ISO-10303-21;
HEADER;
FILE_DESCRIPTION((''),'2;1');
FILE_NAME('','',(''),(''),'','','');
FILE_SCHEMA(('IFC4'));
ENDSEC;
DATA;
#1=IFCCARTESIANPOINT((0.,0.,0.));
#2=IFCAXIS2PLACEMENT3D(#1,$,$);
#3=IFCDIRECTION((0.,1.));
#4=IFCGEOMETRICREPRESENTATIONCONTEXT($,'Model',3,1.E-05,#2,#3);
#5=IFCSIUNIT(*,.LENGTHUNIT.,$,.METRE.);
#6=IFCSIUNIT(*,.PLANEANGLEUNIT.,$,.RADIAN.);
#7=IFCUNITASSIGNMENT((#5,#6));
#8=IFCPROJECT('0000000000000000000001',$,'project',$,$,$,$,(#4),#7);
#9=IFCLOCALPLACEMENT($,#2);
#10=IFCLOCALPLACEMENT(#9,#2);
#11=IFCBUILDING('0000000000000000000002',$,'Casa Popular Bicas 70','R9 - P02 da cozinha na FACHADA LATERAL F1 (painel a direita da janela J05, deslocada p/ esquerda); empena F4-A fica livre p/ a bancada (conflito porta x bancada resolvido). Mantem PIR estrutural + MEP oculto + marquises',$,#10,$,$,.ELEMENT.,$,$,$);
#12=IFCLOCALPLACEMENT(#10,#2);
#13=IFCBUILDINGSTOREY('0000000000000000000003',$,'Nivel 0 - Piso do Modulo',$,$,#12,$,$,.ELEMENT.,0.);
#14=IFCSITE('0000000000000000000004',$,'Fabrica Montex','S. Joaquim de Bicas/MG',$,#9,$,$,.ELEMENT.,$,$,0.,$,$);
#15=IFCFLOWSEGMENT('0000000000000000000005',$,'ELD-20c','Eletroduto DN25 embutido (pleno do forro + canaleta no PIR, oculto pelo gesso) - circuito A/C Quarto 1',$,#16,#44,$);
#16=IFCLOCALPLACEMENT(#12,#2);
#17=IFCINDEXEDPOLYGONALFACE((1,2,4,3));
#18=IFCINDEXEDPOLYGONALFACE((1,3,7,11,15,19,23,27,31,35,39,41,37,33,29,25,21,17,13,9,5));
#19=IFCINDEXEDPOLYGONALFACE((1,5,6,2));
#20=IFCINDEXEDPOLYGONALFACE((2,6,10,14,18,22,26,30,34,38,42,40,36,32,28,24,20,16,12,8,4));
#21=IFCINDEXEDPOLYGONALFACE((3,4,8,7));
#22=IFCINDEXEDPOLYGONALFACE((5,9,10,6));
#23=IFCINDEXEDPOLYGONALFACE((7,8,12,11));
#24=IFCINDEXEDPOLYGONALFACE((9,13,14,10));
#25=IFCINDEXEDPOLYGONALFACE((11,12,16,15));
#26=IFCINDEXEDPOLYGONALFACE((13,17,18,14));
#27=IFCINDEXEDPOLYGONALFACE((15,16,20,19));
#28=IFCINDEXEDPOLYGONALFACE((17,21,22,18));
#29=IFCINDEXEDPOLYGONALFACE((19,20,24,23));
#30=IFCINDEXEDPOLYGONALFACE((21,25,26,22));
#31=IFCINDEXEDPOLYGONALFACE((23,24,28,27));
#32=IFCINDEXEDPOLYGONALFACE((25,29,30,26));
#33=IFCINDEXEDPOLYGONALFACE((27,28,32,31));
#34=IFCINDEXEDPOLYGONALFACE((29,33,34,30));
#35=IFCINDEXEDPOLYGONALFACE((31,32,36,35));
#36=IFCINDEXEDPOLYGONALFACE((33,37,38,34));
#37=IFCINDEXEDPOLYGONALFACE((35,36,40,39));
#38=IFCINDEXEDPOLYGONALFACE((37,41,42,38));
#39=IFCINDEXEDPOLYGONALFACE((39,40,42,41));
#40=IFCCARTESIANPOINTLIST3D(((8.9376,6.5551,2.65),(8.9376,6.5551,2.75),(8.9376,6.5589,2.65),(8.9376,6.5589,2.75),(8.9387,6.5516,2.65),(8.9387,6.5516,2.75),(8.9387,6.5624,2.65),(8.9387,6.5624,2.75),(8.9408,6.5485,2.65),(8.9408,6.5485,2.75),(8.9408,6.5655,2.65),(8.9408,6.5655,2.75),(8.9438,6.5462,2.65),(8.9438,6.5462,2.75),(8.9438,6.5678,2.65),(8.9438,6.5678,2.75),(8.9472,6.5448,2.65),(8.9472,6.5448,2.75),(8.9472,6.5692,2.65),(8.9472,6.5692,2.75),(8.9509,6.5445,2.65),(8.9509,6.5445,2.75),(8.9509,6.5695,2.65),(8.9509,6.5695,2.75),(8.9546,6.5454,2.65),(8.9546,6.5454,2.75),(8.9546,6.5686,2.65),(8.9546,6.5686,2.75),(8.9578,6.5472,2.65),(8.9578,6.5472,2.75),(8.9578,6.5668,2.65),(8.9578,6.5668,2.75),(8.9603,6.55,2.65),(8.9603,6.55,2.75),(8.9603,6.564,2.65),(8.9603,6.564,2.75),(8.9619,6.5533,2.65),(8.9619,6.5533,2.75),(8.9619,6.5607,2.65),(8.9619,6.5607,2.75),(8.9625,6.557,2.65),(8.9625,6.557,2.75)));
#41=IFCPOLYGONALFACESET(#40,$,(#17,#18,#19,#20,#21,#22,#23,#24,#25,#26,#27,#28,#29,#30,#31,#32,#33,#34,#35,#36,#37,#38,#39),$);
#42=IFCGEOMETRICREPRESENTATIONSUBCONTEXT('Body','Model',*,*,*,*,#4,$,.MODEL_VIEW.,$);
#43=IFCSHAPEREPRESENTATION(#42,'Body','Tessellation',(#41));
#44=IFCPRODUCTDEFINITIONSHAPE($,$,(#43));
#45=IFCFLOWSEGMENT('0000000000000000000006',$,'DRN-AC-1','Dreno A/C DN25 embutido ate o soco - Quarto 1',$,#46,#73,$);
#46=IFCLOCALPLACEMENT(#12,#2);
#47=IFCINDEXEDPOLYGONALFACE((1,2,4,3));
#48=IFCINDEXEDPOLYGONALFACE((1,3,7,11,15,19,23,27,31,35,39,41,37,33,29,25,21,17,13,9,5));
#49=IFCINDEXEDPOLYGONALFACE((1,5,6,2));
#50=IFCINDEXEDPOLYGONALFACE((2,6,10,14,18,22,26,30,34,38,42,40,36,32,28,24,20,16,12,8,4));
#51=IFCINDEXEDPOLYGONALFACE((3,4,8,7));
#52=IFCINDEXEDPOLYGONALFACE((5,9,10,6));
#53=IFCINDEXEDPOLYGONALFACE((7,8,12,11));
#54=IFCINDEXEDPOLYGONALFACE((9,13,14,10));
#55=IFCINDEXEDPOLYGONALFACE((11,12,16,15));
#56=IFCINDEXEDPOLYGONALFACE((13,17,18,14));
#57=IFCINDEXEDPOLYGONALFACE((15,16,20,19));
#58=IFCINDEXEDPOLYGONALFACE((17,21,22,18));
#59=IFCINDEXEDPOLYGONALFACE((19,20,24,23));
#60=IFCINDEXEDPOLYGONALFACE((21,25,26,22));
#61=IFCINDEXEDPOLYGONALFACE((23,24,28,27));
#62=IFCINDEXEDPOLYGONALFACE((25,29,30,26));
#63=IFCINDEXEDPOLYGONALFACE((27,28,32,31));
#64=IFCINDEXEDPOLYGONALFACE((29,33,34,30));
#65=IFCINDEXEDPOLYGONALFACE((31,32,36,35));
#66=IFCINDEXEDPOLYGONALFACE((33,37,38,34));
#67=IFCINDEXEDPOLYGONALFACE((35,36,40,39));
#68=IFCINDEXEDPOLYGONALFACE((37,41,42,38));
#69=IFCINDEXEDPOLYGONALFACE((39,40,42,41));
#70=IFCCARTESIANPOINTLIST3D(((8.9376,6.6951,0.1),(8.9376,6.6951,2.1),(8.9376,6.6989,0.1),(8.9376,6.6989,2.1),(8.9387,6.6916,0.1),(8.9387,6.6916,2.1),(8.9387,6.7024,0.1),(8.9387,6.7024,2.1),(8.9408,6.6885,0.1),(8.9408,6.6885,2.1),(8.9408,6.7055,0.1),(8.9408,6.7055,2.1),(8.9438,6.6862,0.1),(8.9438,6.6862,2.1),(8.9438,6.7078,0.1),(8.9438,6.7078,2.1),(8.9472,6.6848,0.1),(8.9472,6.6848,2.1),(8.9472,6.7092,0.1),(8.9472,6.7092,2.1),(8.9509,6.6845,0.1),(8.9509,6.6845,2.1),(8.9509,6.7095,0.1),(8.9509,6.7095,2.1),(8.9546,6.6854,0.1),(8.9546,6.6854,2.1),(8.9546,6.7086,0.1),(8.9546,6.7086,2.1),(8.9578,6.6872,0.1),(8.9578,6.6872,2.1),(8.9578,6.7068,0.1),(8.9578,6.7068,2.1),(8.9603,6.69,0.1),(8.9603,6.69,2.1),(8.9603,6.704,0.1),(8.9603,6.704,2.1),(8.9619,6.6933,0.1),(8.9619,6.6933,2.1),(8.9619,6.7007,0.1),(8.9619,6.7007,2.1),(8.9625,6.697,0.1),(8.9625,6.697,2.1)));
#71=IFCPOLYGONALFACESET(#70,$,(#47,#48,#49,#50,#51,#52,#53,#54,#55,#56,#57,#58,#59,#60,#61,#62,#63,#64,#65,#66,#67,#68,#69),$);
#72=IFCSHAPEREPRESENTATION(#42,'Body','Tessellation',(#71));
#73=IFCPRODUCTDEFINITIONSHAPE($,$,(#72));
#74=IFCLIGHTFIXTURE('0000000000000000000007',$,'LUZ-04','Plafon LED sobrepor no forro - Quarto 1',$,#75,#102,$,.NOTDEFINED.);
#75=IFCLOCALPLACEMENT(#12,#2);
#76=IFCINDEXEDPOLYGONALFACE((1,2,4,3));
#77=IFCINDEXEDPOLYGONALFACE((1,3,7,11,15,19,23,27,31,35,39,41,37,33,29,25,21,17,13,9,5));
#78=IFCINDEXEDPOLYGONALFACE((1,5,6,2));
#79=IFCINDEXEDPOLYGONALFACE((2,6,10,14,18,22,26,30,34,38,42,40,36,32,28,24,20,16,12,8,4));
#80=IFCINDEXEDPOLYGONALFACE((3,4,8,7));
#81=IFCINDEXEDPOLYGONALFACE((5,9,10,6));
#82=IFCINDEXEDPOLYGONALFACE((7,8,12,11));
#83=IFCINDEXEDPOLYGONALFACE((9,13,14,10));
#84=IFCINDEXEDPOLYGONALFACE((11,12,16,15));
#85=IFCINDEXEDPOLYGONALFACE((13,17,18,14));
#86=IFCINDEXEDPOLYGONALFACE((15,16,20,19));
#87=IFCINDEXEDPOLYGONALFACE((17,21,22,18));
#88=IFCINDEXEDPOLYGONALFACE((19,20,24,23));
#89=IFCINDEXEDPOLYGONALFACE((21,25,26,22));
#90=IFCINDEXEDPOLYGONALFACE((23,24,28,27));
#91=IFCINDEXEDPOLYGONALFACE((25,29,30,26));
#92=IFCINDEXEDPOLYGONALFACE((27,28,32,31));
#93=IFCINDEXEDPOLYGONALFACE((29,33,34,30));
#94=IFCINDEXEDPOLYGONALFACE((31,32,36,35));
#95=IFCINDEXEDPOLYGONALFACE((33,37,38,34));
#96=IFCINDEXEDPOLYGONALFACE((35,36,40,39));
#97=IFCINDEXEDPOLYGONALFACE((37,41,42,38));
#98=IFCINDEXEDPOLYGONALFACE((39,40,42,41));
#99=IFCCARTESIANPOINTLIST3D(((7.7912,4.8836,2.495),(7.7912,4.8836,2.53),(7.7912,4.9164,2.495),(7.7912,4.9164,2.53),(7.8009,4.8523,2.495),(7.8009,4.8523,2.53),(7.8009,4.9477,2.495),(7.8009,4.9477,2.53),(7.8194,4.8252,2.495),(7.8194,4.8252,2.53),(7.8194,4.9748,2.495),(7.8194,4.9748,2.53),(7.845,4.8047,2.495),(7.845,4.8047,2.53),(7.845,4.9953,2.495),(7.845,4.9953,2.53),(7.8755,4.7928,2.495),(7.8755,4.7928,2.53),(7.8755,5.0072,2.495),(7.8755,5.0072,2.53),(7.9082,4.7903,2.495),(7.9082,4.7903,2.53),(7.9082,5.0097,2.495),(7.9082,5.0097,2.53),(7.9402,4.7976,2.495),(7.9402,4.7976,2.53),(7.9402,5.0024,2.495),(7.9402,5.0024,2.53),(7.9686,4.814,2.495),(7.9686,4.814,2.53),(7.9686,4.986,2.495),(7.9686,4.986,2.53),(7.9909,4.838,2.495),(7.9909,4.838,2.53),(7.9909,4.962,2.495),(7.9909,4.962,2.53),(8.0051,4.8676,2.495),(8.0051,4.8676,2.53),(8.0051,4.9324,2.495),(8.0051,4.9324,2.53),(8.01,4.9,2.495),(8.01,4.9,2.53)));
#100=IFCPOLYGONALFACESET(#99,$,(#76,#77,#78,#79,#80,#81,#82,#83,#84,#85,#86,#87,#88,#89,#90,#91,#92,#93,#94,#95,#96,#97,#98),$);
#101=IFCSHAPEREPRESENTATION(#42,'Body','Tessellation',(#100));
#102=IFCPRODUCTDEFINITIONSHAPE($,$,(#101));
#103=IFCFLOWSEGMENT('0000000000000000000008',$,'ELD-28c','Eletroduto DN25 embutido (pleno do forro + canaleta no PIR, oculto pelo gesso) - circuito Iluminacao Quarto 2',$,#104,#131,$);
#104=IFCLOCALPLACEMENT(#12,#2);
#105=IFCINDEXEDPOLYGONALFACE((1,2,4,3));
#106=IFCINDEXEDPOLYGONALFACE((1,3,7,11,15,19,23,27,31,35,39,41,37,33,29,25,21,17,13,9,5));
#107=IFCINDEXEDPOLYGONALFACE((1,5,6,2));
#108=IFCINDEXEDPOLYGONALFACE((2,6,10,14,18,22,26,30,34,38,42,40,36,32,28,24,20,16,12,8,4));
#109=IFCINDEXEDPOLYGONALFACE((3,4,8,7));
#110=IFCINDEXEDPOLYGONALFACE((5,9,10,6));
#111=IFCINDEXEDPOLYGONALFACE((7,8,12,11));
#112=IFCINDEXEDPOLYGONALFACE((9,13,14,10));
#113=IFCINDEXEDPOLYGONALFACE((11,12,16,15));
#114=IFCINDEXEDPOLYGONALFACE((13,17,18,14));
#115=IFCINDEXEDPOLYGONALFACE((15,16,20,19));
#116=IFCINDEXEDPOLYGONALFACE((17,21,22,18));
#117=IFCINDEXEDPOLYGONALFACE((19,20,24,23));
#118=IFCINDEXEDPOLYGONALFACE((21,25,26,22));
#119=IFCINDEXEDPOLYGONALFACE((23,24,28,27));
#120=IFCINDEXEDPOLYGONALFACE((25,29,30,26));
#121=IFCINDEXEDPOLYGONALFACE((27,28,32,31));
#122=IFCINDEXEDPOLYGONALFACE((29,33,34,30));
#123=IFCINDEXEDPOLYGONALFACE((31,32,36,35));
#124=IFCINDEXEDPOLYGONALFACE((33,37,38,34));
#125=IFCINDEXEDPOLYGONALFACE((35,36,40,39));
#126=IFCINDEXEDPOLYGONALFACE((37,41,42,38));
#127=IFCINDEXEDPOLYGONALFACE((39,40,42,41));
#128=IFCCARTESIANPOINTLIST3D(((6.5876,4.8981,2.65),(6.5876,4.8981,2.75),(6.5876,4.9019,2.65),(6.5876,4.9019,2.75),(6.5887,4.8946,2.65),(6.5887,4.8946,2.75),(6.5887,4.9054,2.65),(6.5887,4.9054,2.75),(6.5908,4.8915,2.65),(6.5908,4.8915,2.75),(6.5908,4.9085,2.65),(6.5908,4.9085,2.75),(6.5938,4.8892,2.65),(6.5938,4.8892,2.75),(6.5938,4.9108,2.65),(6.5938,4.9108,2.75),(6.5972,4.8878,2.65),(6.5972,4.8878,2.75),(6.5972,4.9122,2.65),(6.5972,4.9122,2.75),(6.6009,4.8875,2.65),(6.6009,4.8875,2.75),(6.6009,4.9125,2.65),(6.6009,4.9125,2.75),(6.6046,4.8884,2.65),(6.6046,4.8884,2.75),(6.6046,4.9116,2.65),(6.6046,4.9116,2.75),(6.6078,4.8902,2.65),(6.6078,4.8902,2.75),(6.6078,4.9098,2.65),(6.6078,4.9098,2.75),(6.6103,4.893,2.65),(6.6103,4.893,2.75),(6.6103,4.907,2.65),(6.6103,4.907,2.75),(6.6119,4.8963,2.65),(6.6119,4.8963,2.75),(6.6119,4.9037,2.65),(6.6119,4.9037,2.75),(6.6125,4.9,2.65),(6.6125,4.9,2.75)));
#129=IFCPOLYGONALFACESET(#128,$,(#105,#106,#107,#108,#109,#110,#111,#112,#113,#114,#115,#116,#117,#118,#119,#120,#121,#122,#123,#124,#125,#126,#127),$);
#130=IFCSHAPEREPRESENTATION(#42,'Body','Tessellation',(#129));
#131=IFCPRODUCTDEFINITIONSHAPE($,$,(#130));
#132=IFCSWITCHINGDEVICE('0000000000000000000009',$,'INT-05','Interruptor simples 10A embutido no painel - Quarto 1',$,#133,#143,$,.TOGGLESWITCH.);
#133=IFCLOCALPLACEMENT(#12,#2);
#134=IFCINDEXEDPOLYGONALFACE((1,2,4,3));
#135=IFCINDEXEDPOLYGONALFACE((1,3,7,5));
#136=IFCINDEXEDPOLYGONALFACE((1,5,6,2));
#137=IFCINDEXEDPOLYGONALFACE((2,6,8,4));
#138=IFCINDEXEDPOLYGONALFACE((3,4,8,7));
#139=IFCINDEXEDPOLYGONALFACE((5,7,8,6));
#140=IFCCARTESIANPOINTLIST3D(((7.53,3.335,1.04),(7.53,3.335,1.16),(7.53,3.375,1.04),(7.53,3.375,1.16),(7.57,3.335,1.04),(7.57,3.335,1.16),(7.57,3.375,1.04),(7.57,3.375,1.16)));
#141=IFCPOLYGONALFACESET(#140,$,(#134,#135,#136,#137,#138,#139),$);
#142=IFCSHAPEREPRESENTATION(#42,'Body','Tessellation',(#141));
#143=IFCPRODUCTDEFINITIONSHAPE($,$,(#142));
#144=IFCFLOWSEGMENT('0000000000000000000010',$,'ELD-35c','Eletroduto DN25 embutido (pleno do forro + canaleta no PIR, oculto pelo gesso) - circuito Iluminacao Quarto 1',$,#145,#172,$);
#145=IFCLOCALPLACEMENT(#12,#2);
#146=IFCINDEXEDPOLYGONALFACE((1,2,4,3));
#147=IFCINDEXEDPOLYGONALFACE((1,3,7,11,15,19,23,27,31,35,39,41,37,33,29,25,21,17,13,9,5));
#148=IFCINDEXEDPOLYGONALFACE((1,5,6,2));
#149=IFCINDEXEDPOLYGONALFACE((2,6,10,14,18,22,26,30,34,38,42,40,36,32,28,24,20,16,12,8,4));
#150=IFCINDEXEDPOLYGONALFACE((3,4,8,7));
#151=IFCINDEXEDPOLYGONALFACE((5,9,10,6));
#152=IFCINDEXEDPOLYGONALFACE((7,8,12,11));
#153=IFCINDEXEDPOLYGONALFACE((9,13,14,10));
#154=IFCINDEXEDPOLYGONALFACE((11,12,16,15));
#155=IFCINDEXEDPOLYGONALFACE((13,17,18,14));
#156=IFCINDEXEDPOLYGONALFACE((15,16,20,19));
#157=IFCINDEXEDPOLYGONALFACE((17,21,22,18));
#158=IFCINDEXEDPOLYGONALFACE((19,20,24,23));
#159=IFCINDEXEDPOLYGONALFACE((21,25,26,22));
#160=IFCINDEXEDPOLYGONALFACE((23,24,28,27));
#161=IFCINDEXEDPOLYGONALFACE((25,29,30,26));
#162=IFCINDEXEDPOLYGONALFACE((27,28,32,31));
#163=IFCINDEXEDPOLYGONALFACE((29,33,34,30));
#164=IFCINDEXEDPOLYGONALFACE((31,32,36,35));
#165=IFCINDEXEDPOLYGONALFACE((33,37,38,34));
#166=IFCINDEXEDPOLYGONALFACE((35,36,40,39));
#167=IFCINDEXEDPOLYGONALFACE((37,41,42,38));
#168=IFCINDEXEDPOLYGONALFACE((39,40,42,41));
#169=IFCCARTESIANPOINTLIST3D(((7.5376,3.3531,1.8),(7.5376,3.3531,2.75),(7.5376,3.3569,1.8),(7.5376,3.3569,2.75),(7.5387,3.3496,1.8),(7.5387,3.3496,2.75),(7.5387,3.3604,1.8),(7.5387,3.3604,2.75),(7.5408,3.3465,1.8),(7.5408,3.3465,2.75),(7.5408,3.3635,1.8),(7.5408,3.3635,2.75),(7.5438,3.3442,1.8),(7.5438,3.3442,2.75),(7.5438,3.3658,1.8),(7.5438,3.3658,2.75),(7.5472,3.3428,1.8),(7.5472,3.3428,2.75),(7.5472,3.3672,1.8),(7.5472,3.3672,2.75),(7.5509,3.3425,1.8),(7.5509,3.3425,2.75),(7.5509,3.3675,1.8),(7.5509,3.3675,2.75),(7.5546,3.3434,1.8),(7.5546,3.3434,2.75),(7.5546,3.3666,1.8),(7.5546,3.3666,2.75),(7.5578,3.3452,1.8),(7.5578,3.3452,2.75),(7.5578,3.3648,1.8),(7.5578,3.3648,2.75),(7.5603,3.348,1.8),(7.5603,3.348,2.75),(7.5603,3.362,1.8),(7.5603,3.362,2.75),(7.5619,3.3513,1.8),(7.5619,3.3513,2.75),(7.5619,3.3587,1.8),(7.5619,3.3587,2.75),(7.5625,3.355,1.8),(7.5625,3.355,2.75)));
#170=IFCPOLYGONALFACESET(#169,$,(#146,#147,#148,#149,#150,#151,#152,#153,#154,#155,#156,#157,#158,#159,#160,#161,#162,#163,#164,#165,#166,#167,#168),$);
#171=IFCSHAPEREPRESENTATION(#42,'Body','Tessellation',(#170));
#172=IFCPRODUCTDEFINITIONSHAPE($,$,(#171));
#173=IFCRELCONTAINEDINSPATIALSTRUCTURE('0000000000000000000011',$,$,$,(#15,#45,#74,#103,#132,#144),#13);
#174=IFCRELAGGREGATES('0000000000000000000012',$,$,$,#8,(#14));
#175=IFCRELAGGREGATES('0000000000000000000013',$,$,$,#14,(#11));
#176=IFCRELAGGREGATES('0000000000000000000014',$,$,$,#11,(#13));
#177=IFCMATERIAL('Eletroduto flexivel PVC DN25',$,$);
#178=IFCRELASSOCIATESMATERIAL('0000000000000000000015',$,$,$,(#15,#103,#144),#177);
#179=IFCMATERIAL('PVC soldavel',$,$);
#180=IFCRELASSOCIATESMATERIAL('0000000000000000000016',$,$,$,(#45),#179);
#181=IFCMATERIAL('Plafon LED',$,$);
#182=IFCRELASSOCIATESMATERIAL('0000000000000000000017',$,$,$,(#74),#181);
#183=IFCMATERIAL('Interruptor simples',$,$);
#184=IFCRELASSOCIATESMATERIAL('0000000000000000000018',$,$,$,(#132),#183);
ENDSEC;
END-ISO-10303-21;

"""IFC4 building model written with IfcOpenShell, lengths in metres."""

from ifc_helpers import new_model, si_unit, direction, frame, frame_2d, origin, origin_2d, place, context, subcontext, project, spatial, rectangle, circle, extrude, material, element, save


model = new_model("IFC4")

# Units and contexts
model_context_1 = context("Model", 3, precision=1e-05, world=origin(), true_north=direction((0.0, 1.0)))
body_context_1 = subcontext(model_context_1, "Body", "Model", "MODEL_VIEW")
ifc_project = project(units=[si_unit("LENGTHUNIT", "METRE"), si_unit("PLANEANGLEUNIT", "RADIAN")], contexts=[model_context_1])

# Site, building, storey
site_placement = place(None, origin())
site = spatial("IfcSite", under=ifc_project, at=site_placement, Name="Fabrica Montex", Description="S. Joaquim de Bicas/MG", CompositionType="ELEMENT", RefElevation=0.0)
building_placement = place(site_placement, origin())
building = spatial("IfcBuilding", under=site, at=building_placement, Name="Casa Popular Bicas 70", Description="R9 - P02 da cozinha na FACHADA LATERAL F1 (painel a direita da janela J05, deslocada p/ esquerda); empena F4-A fica livre p/ a bancada (conflito porta x bancada resolvido). Mantem PIR estrutural + MEP oculto + marquises", CompositionType="ELEMENT")
storey_placement = place(building_placement, origin())
storey = spatial("IfcBuildingStorey", under=building, at=storey_placement, Name="Nivel 0 - Piso do Modulo", CompositionType="ELEMENT", Elevation=0.0)

# Shared definitions
ifc_material_1 = material(Name="Eletroduto flexivel PVC DN25")

# Flow segments
flow_segment_1_placement = place(storey_placement, frame((8.95, 6.557, 2.75), z_axis=(0.0, 0.0, -1.0), x_axis=(1.0, 0.0, 0.0)))
element("IfcFlowSegment", 1, at=flow_segment_1_placement, inside=storey, material=ifc_material_1, Name="ELD-20c", Description="Eletroduto DN25 embutido (pleno do forro + canaleta no PIR, oculto pelo gesso) - circuito A/C Quarto 1", context=body_context_1, shape_type="SweptSolid", body=[
    extrude(circle(Radius=0.0125, at=origin_2d()), origin(), (0.0, 0.0, 1.0), 0.1),
])
ifc_material_2 = material(Name="PVC soldavel")
flow_segment_2_placement = place(storey_placement, frame((8.95, 6.697, 2.1), z_axis=(0.0, 0.0, -1.0), x_axis=(1.0, 0.0, 0.0)))
element("IfcFlowSegment", 2, at=flow_segment_2_placement, inside=storey, material=ifc_material_2, Name="DRN-AC-1", Description="Dreno A/C DN25 embutido ate o soco - Quarto 1", context=body_context_1, shape_type="SweptSolid", body=[
    extrude(circle(Radius=0.0125, at=origin_2d()), origin(), (0.0, 0.0, 1.0), 2.0),
])

# Light fixture
ifc_material_3 = material(Name="Plafon LED")
light_fixture_placement = place(storey_placement, frame((7.9, 4.9, 2.495)))
element("IfcLightFixture", 3, at=light_fixture_placement, inside=storey, material=ifc_material_3, Name="LUZ-04", Description="Plafon LED sobrepor no forro - Quarto 1", PredefinedType="NOTDEFINED", context=body_context_1, shape_type="SweptSolid", body=[
    extrude(circle(Radius=0.11, at=origin_2d()), origin(), (0.0, 0.0, 1.0), 0.035),
])

# Flow segment
flow_segment_3_placement = place(storey_placement, frame((6.6, 4.9, 2.75), z_axis=(0.0, 0.0, -1.0), x_axis=(1.0, 0.0, 0.0)))
element("IfcFlowSegment", 4, at=flow_segment_3_placement, inside=storey, material=ifc_material_1, Name="ELD-28c", Description="Eletroduto DN25 embutido (pleno do forro + canaleta no PIR, oculto pelo gesso) - circuito Iluminacao Quarto 2", context=body_context_1, shape_type="SweptSolid", body=[
    extrude(circle(Radius=0.0125, at=origin_2d()), origin(), (0.0, 0.0, 1.0), 0.1),
])

# Switching device
ifc_material_4 = material(Name="Interruptor simples")
switching_device_placement = place(storey_placement, frame((7.53, 3.335, 1.04)))
element("IfcSwitchingDevice", 5, at=switching_device_placement, inside=storey, material=ifc_material_4, Name="INT-05", Description="Interruptor simples 10A embutido no painel - Quarto 1", PredefinedType="TOGGLESWITCH", context=body_context_1, shape_type="SweptSolid", body=[
    extrude(rectangle(XDim=0.04, YDim=0.04, at=frame_2d((0.02, 0.02))), origin(), (0.0, 0.0, 1.0), 0.12),
])

# Flow segment
flow_segment_4_placement = place(storey_placement, frame((7.55, 3.355, 2.75), z_axis=(0.0, 0.0, -1.0), x_axis=(1.0, 0.0, 0.0)))
element("IfcFlowSegment", 6, at=flow_segment_4_placement, inside=storey, material=ifc_material_1, Name="ELD-35c", Description="Eletroduto DN25 embutido (pleno do forro + canaleta no PIR, oculto pelo gesso) - circuito Iluminacao Quarto 1", context=body_context_1, shape_type="SweptSolid", body=[
    extrude(circle(Radius=0.0125, at=origin_2d()), origin(), (0.0, 0.0, 1.0), 0.95),
])

save(model, "model.ifc")
